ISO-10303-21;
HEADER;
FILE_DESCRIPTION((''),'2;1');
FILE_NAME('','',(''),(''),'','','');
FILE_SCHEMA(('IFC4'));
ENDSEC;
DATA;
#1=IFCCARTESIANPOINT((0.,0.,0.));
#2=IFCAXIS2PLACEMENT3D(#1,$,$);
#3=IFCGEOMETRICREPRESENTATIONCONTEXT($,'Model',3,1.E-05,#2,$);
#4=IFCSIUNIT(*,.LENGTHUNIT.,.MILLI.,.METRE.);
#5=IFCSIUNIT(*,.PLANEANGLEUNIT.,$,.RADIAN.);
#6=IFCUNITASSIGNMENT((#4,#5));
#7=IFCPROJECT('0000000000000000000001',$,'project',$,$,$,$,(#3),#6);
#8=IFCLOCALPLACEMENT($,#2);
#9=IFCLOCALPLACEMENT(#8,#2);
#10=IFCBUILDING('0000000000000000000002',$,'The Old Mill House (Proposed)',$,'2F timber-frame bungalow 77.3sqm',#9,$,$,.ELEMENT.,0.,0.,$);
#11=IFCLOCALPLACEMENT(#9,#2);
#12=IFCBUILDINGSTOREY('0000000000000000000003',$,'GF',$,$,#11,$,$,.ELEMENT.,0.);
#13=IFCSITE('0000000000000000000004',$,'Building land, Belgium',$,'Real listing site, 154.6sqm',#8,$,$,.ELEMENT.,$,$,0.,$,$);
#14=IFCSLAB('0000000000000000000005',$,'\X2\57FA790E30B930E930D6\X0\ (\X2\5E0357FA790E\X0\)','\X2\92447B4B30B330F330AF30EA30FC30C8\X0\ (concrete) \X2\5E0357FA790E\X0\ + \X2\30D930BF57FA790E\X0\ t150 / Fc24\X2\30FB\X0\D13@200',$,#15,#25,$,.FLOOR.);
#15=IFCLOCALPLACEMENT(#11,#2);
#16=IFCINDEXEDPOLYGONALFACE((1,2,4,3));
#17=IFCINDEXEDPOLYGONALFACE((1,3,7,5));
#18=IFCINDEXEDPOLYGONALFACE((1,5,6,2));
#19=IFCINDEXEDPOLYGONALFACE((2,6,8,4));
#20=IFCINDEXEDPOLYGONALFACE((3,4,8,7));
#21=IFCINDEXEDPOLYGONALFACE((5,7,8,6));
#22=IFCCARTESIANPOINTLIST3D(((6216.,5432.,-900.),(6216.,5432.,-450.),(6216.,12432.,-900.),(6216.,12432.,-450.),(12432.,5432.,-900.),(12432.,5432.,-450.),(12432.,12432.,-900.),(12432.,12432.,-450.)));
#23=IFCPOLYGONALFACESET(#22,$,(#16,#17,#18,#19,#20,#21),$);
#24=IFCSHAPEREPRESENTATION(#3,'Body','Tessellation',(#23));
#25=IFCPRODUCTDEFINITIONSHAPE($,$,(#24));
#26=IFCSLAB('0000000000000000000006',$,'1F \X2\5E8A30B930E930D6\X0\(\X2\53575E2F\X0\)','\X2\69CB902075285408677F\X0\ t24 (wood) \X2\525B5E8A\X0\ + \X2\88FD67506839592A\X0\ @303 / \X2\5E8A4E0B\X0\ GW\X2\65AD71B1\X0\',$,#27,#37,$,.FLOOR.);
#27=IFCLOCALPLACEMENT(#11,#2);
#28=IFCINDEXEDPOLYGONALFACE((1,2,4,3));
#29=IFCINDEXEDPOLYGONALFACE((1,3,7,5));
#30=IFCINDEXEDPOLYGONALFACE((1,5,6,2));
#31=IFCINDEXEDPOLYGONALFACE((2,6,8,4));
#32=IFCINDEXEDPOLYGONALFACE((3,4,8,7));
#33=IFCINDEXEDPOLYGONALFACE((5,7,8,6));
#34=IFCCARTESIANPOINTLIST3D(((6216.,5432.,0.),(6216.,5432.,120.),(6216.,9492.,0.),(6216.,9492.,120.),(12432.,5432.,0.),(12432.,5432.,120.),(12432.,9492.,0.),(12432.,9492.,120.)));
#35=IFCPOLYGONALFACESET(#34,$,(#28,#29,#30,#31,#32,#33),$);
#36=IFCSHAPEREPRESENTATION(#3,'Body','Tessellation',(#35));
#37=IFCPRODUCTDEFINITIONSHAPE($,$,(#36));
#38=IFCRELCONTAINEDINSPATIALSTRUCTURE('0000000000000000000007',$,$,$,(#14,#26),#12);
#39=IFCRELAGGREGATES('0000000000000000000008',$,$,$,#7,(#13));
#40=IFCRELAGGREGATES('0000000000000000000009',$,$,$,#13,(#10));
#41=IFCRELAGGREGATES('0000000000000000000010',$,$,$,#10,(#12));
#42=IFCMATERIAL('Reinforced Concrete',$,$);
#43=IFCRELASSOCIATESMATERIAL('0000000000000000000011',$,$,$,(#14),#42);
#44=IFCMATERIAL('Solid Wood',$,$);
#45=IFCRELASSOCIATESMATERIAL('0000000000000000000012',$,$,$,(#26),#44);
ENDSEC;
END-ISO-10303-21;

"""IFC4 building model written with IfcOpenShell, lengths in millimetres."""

from ifc_helpers import new_model, si_unit, frame, frame_2d, origin, place, context, project, spatial, rectangle, extrude, material, element, save


model = new_model("IFC4")

# Units and contexts
model_context = context("Model", 3, precision=1e-05, world=origin())
ifc_project = project(units=[si_unit("LENGTHUNIT", "METRE", prefix="MILLI"), si_unit("PLANEANGLEUNIT", "RADIAN")], contexts=[model_context])

# Site, building, storey
site_placement = place(None, origin())
site = spatial("IfcSite", under=ifc_project, at=site_placement, Name="Building land, Belgium", ObjectType="Real listing site, 154.6sqm", CompositionType="ELEMENT", RefElevation=0.0)
building_placement = place(site_placement, origin())
building = spatial("IfcBuilding", under=site, at=building_placement, Name="The Old Mill House (Proposed)", ObjectType="2F timber-frame bungalow 77.3sqm", CompositionType="ELEMENT", ElevationOfRefHeight=0.0, ElevationOfTerrain=0.0)
storey_placement = place(building_placement, origin())
storey = spatial("IfcBuildingStorey", under=building, at=storey_placement, Name="GF", CompositionType="ELEMENT", Elevation=0.0)

# Slabs
ifc_material_1 = material(Name="Reinforced Concrete")
slab_1_placement = place(storey_placement, frame((3108.0, 2716.0, -450.0)))
element("IfcSlab", 1, at=slab_1_placement, inside=storey, material=ifc_material_1, Name="基礎スラブ (布基礎)", Description="鉄筋コンクリート (concrete) 布基礎 + ベタ基礎 t150 / Fc24・D13@200", PredefinedType="FLOOR", context=model_context, shape_type="SweptSolid", body=[
    extrude(rectangle(XDim=6216.0, YDim=7000.0, at=frame_2d((3108.0, 3500.0))), frame((3108.0, 2716.0, -450.0)), (0.0, 0.0, 1.0), 450.0),
])
ifc_material_2 = material(Name="Solid Wood")
slab_2_placement = place(storey_placement, frame((3108.0, 2716.0, 0.0)))
element("IfcSlab", 2, at=slab_2_placement, inside=storey, material=ifc_material_2, Name="1F 床スラブ(南帯)", Description="構造用合板 t24 (wood) 剛床 + 製材根太 @303 / 床下 GW断熱", PredefinedType="FLOOR", context=model_context, shape_type="SweptSolid", body=[
    extrude(rectangle(XDim=6216.0, YDim=4060.0, at=frame_2d((3108.0, 2030.0))), frame((3108.0, 2716.0, 0.0)), (0.0, 0.0, 1.0), 120.0),
])

save(model, "model.ifc")
